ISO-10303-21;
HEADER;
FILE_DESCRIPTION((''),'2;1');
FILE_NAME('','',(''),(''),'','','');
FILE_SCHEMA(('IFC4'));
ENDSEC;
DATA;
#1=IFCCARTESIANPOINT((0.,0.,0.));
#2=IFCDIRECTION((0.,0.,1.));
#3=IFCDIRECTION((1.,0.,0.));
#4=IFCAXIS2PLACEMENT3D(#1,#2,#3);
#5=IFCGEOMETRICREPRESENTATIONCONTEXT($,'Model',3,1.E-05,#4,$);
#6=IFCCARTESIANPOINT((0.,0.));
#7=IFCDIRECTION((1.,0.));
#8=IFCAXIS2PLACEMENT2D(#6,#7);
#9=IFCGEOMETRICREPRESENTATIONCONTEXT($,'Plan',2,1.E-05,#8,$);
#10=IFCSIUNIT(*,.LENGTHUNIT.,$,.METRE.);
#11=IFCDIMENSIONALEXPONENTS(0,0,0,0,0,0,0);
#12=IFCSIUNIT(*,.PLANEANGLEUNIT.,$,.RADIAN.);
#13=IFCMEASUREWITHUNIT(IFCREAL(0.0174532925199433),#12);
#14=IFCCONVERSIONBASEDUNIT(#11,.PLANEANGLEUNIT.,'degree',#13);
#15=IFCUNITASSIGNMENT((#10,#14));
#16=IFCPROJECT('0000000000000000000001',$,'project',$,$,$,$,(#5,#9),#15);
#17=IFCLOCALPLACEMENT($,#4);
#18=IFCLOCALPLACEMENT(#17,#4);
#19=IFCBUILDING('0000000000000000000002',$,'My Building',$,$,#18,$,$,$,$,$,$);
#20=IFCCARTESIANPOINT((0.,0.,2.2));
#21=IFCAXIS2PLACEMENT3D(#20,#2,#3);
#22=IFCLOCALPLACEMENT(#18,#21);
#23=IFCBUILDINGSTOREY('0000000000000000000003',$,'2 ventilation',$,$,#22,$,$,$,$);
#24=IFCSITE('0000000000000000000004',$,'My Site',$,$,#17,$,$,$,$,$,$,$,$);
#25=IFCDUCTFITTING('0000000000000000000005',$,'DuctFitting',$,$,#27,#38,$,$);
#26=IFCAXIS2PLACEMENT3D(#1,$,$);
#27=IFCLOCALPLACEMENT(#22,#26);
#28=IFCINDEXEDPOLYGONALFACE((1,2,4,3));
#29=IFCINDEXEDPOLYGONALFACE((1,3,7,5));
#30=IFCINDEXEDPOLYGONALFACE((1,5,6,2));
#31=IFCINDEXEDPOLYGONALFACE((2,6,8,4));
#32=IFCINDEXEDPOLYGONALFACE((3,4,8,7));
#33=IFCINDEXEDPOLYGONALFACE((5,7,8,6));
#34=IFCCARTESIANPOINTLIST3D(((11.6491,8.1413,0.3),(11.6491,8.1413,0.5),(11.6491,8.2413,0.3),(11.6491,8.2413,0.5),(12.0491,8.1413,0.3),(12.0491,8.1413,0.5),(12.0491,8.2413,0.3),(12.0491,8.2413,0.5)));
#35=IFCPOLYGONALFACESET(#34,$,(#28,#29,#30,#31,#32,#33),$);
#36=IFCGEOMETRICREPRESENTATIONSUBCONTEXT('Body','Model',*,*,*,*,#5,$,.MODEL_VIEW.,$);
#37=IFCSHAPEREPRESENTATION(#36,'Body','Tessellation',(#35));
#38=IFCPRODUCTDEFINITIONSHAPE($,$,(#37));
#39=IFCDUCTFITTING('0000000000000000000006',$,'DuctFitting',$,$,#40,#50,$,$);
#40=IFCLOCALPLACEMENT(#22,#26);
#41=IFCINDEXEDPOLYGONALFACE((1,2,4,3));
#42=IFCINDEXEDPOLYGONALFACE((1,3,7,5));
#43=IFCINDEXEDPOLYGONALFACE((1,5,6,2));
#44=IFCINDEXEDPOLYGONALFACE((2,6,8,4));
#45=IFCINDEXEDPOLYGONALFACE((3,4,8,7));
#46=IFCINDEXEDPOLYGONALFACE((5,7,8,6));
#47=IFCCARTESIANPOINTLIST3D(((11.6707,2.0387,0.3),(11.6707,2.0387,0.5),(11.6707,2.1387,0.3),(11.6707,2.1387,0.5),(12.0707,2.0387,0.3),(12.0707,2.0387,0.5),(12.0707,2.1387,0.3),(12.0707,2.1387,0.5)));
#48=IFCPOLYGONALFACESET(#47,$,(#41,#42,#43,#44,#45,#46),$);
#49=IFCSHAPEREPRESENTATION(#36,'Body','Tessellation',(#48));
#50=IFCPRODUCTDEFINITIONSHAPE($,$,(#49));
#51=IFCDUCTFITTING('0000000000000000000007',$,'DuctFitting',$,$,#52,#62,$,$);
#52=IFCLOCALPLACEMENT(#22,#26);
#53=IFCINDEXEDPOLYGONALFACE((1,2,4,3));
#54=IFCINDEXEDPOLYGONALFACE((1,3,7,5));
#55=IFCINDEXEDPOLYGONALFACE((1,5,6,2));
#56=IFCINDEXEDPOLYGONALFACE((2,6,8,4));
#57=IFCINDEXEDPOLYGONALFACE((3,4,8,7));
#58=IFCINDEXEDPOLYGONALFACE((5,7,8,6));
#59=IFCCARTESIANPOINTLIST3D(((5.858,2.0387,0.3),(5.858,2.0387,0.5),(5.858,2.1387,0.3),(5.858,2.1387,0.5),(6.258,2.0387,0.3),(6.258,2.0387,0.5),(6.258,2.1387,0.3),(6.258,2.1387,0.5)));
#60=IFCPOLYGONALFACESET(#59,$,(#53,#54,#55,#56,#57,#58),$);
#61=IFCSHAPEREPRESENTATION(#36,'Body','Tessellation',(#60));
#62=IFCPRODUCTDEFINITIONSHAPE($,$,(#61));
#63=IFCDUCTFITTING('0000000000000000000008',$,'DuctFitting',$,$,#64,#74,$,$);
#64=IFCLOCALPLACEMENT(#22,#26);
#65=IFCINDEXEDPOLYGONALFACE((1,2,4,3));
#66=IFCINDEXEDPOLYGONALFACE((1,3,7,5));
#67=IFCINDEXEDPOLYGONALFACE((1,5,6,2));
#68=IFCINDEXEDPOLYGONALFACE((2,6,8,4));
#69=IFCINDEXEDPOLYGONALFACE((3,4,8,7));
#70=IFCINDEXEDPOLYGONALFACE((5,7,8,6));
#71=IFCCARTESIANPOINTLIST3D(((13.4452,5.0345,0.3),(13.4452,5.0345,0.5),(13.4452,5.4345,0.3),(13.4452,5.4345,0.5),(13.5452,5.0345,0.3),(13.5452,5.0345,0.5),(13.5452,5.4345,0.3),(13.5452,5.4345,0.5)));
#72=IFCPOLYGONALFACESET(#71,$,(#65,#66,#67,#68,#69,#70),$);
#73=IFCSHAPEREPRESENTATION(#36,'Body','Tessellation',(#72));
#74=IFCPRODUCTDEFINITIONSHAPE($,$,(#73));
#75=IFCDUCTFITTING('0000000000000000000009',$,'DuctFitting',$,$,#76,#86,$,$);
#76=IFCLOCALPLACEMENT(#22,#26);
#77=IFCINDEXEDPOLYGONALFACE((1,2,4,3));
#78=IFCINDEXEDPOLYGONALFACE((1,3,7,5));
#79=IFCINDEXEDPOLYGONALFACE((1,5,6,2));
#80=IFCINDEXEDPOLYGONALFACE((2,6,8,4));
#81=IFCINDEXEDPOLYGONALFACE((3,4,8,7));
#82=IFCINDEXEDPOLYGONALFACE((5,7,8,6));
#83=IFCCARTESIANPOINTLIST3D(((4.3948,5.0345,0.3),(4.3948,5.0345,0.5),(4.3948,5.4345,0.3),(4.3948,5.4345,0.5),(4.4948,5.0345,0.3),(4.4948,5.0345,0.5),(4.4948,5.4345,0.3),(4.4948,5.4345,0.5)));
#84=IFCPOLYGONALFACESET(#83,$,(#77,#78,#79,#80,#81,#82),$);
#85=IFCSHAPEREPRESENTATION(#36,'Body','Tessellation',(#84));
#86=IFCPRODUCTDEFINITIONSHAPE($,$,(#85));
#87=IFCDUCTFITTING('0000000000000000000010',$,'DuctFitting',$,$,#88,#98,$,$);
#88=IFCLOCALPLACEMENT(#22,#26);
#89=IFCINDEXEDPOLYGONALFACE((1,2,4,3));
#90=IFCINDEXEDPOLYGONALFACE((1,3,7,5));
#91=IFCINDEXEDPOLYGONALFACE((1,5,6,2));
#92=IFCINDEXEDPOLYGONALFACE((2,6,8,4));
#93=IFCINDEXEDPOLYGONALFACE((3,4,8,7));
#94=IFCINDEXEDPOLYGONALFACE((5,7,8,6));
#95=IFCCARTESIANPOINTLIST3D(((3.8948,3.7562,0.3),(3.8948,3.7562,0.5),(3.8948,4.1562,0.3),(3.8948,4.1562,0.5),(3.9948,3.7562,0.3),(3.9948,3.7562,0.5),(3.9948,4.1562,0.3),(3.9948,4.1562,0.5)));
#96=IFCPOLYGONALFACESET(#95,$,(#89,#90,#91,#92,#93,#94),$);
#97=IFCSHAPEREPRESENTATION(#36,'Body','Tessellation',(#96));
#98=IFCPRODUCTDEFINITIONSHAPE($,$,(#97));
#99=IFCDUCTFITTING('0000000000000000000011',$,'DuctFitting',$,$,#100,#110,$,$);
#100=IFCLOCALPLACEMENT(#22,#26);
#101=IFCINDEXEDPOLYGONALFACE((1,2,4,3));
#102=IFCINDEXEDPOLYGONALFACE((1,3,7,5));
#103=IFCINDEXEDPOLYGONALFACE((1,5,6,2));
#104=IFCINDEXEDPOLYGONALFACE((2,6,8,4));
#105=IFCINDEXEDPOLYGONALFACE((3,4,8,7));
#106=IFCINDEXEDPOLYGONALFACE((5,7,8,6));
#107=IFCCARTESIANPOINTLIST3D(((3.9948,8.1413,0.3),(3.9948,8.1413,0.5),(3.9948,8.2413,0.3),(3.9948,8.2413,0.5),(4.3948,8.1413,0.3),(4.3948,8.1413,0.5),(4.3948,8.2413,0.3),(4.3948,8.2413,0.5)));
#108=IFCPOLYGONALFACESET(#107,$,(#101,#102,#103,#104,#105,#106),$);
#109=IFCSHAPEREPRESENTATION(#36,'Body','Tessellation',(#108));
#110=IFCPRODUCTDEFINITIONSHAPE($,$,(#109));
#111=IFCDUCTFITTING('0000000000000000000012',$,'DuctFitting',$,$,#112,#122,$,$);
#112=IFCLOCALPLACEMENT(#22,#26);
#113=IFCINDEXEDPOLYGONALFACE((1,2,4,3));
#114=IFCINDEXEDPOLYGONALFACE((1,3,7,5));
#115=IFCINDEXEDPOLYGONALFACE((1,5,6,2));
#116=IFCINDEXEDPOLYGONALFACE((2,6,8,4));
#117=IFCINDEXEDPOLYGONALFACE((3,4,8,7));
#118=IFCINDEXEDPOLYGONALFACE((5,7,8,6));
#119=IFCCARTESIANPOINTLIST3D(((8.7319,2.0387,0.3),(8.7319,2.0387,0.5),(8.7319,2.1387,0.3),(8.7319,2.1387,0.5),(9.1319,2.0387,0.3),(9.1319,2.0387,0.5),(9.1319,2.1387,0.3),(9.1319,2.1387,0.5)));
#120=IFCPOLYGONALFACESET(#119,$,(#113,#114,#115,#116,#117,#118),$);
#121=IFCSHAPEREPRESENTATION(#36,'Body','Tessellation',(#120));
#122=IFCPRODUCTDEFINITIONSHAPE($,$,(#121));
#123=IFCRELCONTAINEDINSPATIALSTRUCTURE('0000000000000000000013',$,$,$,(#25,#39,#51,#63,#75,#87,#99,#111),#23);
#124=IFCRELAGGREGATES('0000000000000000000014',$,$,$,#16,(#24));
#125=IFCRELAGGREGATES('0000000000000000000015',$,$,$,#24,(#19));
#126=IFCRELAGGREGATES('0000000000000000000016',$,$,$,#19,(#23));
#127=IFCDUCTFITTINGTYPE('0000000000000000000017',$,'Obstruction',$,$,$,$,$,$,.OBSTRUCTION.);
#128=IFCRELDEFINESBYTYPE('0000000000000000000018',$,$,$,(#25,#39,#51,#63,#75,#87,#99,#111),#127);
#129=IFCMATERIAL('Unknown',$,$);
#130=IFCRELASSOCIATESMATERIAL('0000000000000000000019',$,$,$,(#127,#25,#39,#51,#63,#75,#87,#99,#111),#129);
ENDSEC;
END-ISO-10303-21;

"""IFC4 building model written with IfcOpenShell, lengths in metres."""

from ifc_helpers import new_model, entity, si_unit, converted_unit, frame, origin_with_axes, origin_2d_with_axis, place, context, subcontext, project, spatial, indexed_curve, outline, extrude, material, material_profile, profile_set, profile_usage, type_object, element, save


model = new_model("IFC4")

# Units and contexts
model_context = context("Model", 3, precision=1e-05, world=origin_with_axes())
plan_context = context("Plan", 2, precision=1e-05, world=origin_2d_with_axis())
body_context = subcontext(model_context, "Body", "Model", "MODEL_VIEW")
ifc_project = project(units=[si_unit("LENGTHUNIT", "METRE"), converted_unit("PLANEANGLEUNIT", "degree", entity("IfcReal", 0.0174532925199433), si_unit("PLANEANGLEUNIT", "RADIAN"), dimensions=[0, 0, 0, 0, 0, 0, 0])], contexts=[model_context, plan_context])

# Site, building, storey
site_placement = place(None, origin_with_axes())
site = spatial("IfcSite", under=ifc_project, at=site_placement, Name="My Site")
building_placement = place(site_placement, origin_with_axes())
building = spatial("IfcBuilding", under=site, at=building_placement, Name="My Building")
storey_placement = place(building_placement, frame((0.0, 0.0, 2.2), z_axis=(0.0, 0.0, 1.0), x_axis=(1.0, 0.0, 0.0)))
storey = spatial("IfcBuildingStorey", under=building, at=storey_placement, Name="2 ventilation")

# Shared definitions
ifc_material = material(Name="Unknown")

# Duct fittings
ifc_material_profile_1 = material_profile(ifc_material, outline(indexed_curve([(-0.2, 0.1), (0.2, 0.1), (0.2, -0.1), (-0.2, -0.1), (-0.2, 0.1)])))
ifc_profile_set_1 = profile_set([ifc_material_profile_1])
duct_fitting_type_1 = type_object("IfcDuctFittingType", Name="Obstruction", PredefinedType="OBSTRUCTION", material=ifc_profile_set_1)
ifc_profile_usage_1 = profile_usage(ifc_profile_set_1, cardinal=2)
duct_fitting_1_placement = place(storey_placement, frame((11.8491, 8.1413, 0.3), z_axis=(0.0, 1.0, 0.000007), x_axis=(-1.0, 0.0, 0.0)))
element("IfcDuctFitting", 1, at=duct_fitting_1_placement, inside=storey, type_object=duct_fitting_type_1, material=ifc_profile_usage_1, Name="DuctFitting", context=body_context, shape_type="SweptSolid", body=[
    extrude(outline(indexed_curve([(-0.2, 0.1), (0.2, 0.1), (0.2, -0.1), (-0.2, -0.1), (-0.2, 0.1)])), frame((0.0, 0.1, 0.0), z_axis=(0.0, 0.0, 1.0), x_axis=(1.0, 0.0, 0.0)), (0.0, 0.0, 1.0), 0.1),
])
ifc_profile_usage_2 = profile_usage(ifc_profile_set_1, cardinal=2)
duct_fitting_2_placement = place(storey_placement, frame((11.8707, 2.1387, 0.3), z_axis=(0.0, -1.0, 0.000007), x_axis=(1.0, 0.0, 0.0)))
element("IfcDuctFitting", 2, at=duct_fitting_2_placement, inside=storey, type_object=duct_fitting_type_1, material=ifc_profile_usage_2, Name="DuctFitting", context=body_context, shape_type="SweptSolid", body=[
    extrude(outline(indexed_curve([(-0.2, 0.1), (0.2, 0.1), (0.2, -0.1), (-0.2, -0.1), (-0.2, 0.1)])), frame((0.0, 0.1, 0.0), z_axis=(0.0, 0.0, 1.0), x_axis=(1.0, 0.0, 0.0)), (0.0, 0.0, 1.0), 0.1),
])
ifc_profile_usage_3 = profile_usage(ifc_profile_set_1, cardinal=2)
duct_fitting_3_placement = place(storey_placement, frame((6.058, 2.1387, 0.3), z_axis=(0.0, -1.0, 0.000007), x_axis=(1.0, 0.0, 0.0)))
element("IfcDuctFitting", 3, at=duct_fitting_3_placement, inside=storey, type_object=duct_fitting_type_1, material=ifc_profile_usage_3, Name="DuctFitting", context=body_context, shape_type="SweptSolid", body=[
    extrude(outline(indexed_curve([(-0.2, 0.1), (0.2, 0.1), (0.2, -0.1), (-0.2, -0.1), (-0.2, 0.1)])), frame((0.0, 0.1, 0.0), z_axis=(0.0, 0.0, 1.0), x_axis=(1.0, 0.0, 0.0)), (0.0, 0.0, 1.0), 0.1),
])
ifc_profile_usage_4 = profile_usage(ifc_profile_set_1, cardinal=2)
duct_fitting_4_placement = place(storey_placement, frame((13.4452, 5.2345, 0.3), z_axis=(1.0, 0.0, 0.000007), x_axis=(0.0, 1.0, 0.0)))
element("IfcDuctFitting", 4, at=duct_fitting_4_placement, inside=storey, type_object=duct_fitting_type_1, material=ifc_profile_usage_4, Name="DuctFitting", context=body_context, shape_type="SweptSolid", body=[
    extrude(outline(indexed_curve([(-0.2, 0.1), (0.2, 0.1), (0.2, -0.1), (-0.2, -0.1), (-0.2, 0.1)])), frame((0.0, 0.1, 0.0), z_axis=(0.0, 0.0, 1.0), x_axis=(1.0, 0.0, 0.0)), (0.0, 0.0, 1.0), 0.1),
])
ifc_profile_usage_5 = profile_usage(ifc_profile_set_1, cardinal=2)
duct_fitting_5_placement = place(storey_placement, frame((4.4948, 5.2345, 0.3), z_axis=(-1.0, 0.0, 0.000007), x_axis=(0.0, -1.0, 0.0)))
element("IfcDuctFitting", 5, at=duct_fitting_5_placement, inside=storey, type_object=duct_fitting_type_1, material=ifc_profile_usage_5, Name="DuctFitting", context=body_context, shape_type="SweptSolid", body=[
    extrude(outline(indexed_curve([(-0.2, 0.1), (0.2, 0.1), (0.2, -0.1), (-0.2, -0.1), (-0.2, 0.1)])), frame((0.0, 0.1, 0.0), z_axis=(0.0, 0.0, 1.0), x_axis=(1.0, 0.0, 0.0)), (0.0, 0.0, 1.0), 0.1),
])
ifc_profile_usage_6 = profile_usage(ifc_profile_set_1, cardinal=2)
duct_fitting_6_placement = place(storey_placement, frame((3.8948, 3.9562, 0.3), z_axis=(1.0, 0.0, 0.000007), x_axis=(0.0, 1.0, 0.0)))
element("IfcDuctFitting", 6, at=duct_fitting_6_placement, inside=storey, type_object=duct_fitting_type_1, material=ifc_profile_usage_6, Name="DuctFitting", context=body_context, shape_type="SweptSolid", body=[
    extrude(outline(indexed_curve([(-0.2, 0.1), (0.2, 0.1), (0.2, -0.1), (-0.2, -0.1), (-0.2, 0.1)])), frame((0.0, 0.1, 0.0), z_axis=(0.0, 0.0, 1.0), x_axis=(1.0, 0.0, 0.0)), (0.0, 0.0, 1.0), 0.1),
])
ifc_profile_usage_7 = profile_usage(ifc_profile_set_1, cardinal=2)
duct_fitting_7_placement = place(storey_placement, frame((4.1948, 8.2413, 0.3), z_axis=(0.0, -1.0, 0.000001), x_axis=(1.0, 0.0, 0.0)))
element("IfcDuctFitting", 7, at=duct_fitting_7_placement, inside=storey, type_object=duct_fitting_type_1, material=ifc_profile_usage_7, Name="DuctFitting", context=body_context, shape_type="SweptSolid", body=[
    extrude(outline(indexed_curve([(-0.2, 0.1), (0.2, 0.1), (0.2, -0.1), (-0.2, -0.1), (-0.2, 0.1)])), frame((0.0, 0.1, 0.0), z_axis=(0.0, 0.0, 1.0), x_axis=(1.0, 0.0, 0.0)), (0.0, 0.0, 1.0), 0.1),
])
ifc_profile_usage_8 = profile_usage(ifc_profile_set_1, cardinal=2)
duct_fitting_8_placement = place(storey_placement, frame((8.9319, 2.1387, 0.3), z_axis=(0.0, -1.0, 0.000007), x_axis=(1.0, 0.0, 0.0)))
element("IfcDuctFitting", 8, at=duct_fitting_8_placement, inside=storey, type_object=duct_fitting_type_1, material=ifc_profile_usage_8, Name="DuctFitting", context=body_context, shape_type="SweptSolid", body=[
    extrude(outline(indexed_curve([(-0.2, 0.1), (0.2, 0.1), (0.2, -0.1), (-0.2, -0.1), (-0.2, 0.1)])), frame((0.0, 0.1, 0.0), z_axis=(0.0, 0.0, 1.0), x_axis=(1.0, 0.0, 0.0)), (0.0, 0.0, 1.0), 0.1),
])

save(model, "model.ifc")
